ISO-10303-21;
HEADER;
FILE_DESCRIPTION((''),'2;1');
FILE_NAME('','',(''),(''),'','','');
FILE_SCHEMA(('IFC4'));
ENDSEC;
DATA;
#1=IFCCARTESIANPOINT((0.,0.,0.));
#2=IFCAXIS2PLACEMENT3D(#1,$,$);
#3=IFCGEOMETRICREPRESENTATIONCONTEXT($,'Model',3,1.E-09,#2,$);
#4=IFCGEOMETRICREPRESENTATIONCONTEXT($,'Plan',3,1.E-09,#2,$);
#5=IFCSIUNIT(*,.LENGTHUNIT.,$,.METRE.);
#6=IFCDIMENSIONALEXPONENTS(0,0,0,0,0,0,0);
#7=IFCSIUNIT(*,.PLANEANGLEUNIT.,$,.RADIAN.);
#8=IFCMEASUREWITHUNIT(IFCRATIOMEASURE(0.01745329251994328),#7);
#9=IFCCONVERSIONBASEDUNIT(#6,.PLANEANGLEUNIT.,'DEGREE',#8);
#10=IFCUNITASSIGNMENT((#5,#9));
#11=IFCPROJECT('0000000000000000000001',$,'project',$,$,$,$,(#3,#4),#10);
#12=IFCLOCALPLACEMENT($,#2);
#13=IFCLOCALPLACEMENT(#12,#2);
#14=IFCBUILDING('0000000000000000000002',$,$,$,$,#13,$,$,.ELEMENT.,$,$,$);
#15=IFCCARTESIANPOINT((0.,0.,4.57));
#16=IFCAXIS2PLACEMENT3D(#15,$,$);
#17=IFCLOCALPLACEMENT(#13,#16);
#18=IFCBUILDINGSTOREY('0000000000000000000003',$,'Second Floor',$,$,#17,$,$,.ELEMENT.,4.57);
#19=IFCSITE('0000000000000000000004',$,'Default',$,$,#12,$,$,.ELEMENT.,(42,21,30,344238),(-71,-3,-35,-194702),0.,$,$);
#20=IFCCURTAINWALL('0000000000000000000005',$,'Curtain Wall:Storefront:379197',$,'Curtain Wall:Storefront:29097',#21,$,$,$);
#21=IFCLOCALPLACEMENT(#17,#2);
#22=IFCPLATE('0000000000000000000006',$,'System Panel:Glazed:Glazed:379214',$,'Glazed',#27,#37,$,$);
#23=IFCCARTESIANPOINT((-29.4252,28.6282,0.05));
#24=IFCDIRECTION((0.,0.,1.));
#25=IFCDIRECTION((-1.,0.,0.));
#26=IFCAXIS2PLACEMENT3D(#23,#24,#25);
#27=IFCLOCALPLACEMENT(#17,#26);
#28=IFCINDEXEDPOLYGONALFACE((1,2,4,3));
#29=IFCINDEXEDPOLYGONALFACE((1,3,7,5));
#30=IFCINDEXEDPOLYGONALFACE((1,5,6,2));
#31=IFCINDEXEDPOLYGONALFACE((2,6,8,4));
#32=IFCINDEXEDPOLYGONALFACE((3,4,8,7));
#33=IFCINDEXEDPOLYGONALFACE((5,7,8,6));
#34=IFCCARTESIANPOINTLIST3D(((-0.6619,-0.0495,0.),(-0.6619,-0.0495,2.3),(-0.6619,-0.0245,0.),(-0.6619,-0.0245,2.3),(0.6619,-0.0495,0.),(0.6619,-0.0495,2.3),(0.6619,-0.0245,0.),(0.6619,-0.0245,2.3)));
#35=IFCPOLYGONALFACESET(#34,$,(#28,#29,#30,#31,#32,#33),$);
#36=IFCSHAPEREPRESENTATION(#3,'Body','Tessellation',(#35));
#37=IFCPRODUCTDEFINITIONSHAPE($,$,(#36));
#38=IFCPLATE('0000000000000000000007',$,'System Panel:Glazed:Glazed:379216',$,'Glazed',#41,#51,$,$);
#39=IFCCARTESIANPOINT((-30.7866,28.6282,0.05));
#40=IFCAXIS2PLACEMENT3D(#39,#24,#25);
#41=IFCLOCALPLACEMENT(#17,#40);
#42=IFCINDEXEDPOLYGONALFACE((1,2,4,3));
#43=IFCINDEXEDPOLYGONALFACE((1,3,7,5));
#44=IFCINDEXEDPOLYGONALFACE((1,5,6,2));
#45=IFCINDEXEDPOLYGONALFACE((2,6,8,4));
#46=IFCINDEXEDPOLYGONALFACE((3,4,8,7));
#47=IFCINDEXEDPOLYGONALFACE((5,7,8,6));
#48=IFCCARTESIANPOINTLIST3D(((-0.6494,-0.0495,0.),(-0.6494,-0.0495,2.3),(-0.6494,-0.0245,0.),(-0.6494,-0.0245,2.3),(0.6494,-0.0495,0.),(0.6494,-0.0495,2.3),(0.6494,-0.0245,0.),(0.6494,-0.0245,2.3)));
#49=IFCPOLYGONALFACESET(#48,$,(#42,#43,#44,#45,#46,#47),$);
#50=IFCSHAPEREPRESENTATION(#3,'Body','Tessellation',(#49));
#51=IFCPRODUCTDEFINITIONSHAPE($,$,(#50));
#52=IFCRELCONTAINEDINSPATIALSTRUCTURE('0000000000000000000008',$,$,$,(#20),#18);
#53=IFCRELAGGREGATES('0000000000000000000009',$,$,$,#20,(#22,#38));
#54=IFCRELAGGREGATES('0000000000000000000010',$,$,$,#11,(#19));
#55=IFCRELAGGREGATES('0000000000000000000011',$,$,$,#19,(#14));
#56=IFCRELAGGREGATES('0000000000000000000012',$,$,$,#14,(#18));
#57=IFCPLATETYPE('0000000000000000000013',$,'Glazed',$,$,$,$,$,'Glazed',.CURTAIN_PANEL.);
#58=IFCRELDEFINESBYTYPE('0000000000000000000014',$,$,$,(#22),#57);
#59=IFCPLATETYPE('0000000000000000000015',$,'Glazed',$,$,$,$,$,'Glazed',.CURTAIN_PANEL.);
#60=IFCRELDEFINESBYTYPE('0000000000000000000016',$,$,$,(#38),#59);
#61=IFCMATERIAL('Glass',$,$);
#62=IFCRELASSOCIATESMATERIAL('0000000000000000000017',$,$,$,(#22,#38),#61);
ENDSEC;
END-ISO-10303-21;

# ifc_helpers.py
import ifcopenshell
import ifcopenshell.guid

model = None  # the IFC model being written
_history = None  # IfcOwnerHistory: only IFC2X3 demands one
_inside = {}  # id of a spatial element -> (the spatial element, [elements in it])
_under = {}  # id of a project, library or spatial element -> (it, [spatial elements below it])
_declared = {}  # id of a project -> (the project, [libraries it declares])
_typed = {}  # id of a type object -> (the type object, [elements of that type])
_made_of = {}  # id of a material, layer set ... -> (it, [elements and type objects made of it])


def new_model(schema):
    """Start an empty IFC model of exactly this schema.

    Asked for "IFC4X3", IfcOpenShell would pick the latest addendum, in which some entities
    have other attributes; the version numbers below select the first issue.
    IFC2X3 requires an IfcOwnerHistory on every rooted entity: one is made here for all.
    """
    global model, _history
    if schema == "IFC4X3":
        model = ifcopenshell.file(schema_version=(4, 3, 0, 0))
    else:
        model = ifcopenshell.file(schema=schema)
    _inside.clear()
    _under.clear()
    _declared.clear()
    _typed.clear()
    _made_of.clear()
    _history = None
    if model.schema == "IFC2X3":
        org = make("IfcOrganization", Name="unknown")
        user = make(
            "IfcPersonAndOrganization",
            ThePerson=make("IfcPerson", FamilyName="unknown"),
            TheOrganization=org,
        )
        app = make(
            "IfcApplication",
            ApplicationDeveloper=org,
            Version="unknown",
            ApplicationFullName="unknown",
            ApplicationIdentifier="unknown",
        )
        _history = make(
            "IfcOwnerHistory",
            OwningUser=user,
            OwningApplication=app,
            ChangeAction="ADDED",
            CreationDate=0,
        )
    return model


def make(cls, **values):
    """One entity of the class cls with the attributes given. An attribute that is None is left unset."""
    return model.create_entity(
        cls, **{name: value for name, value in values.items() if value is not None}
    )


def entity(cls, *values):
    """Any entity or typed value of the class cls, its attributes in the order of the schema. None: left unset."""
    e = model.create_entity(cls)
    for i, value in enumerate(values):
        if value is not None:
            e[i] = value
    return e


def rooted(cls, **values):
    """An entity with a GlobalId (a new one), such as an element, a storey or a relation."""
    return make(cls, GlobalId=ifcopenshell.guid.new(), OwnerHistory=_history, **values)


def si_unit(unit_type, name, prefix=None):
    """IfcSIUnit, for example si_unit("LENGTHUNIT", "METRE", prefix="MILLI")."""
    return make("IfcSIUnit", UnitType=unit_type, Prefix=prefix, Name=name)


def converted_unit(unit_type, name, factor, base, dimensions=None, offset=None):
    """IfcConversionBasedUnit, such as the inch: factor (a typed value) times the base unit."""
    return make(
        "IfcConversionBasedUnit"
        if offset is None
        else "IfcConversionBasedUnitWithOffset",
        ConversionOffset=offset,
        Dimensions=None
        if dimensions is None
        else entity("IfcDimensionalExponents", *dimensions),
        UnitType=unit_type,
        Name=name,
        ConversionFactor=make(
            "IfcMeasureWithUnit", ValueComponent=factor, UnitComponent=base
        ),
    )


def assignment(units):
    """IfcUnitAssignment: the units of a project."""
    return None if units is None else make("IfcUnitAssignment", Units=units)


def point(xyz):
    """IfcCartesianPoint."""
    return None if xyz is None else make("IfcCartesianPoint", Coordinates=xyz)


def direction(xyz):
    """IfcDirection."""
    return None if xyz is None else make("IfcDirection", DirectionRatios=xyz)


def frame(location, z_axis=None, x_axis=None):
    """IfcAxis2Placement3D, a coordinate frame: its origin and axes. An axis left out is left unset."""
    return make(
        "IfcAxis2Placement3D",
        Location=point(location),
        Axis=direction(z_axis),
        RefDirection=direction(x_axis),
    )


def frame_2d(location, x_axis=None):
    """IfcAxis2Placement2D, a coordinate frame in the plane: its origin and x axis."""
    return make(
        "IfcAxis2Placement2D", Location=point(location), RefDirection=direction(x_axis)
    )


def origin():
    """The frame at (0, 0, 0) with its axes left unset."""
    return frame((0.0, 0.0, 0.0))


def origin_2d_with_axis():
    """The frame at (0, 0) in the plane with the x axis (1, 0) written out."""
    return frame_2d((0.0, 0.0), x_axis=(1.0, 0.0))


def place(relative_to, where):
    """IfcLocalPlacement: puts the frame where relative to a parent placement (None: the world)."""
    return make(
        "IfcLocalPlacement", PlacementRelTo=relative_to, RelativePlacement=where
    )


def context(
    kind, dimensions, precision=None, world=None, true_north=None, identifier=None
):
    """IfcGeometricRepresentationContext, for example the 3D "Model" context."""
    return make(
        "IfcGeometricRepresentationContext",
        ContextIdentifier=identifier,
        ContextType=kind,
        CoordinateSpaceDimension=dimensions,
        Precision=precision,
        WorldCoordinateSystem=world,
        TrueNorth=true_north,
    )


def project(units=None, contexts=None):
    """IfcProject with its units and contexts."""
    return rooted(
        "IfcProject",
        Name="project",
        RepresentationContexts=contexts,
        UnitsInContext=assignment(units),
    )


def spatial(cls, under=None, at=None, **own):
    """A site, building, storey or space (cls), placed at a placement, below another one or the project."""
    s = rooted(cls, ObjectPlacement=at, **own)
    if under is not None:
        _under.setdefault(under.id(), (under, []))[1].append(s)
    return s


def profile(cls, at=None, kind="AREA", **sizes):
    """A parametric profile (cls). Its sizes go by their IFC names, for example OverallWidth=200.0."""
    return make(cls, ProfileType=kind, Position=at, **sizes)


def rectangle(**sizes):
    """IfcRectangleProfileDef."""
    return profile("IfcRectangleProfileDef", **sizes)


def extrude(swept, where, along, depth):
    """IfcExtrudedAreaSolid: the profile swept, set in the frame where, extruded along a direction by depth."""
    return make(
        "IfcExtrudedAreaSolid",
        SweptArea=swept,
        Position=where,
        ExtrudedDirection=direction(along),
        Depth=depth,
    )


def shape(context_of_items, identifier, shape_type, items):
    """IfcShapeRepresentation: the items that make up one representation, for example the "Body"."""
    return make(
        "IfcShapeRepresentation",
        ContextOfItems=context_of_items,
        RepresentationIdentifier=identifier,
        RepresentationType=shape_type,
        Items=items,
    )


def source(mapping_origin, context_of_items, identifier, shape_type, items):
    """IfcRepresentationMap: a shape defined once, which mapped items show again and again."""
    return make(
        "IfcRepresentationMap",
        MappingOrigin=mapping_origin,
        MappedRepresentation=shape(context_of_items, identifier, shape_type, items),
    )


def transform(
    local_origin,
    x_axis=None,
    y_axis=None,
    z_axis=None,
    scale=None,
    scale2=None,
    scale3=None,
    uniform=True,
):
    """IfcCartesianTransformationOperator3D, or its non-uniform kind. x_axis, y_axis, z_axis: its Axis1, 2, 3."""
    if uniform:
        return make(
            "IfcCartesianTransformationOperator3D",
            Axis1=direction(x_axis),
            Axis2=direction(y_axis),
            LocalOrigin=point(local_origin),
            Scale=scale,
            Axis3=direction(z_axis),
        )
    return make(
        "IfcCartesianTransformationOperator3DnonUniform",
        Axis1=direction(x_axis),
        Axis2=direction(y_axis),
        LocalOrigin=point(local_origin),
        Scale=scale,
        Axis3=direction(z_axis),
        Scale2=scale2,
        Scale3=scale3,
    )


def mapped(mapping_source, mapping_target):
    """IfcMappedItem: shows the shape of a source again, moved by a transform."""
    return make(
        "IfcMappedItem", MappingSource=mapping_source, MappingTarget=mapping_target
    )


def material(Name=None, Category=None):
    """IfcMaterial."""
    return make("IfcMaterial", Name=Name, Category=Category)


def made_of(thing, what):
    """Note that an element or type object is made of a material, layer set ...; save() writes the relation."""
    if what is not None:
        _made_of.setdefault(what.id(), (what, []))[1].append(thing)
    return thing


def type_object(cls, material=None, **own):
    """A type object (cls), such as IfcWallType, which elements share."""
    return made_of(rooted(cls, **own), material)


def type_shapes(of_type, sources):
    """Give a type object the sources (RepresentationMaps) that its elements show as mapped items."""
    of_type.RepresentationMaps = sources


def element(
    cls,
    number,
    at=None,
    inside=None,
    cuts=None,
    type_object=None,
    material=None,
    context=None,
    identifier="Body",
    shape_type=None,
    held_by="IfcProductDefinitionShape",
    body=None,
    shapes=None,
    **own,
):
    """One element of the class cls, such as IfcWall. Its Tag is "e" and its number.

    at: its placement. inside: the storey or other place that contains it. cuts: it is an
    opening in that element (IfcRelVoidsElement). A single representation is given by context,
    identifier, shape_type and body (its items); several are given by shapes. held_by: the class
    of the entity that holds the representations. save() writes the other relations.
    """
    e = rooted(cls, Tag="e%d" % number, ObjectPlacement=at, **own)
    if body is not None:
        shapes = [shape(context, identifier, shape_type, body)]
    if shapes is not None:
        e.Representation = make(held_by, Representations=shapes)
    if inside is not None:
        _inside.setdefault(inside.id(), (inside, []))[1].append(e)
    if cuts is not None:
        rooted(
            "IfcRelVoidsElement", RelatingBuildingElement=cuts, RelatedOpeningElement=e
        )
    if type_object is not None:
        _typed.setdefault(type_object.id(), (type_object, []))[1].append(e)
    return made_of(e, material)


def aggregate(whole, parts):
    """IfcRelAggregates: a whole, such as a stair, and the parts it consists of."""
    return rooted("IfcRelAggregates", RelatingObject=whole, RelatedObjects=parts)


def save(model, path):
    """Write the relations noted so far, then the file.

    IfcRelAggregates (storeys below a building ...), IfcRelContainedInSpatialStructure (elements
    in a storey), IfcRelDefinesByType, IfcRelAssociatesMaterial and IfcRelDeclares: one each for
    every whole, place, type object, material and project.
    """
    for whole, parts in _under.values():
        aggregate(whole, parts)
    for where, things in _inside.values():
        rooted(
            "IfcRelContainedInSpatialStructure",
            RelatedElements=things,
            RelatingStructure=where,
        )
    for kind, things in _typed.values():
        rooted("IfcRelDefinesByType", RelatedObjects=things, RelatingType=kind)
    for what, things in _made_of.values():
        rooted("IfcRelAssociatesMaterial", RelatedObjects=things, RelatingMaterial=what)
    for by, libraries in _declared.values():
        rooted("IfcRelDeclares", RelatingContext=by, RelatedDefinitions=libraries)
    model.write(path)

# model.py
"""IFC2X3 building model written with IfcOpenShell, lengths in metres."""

from ifc_helpers import new_model, entity, si_unit, converted_unit, frame, origin, origin_2d_with_axis, place, context, project, spatial, rectangle, extrude, source, transform, mapped, material, type_object, type_shapes, element, aggregate, save


model = new_model("IFC2X3")

# Units and contexts
model_context = context("Model", 3, precision=1e-09, world=origin())
plan_context = context("Plan", 3, precision=1e-09, world=origin())
ifc_project = project(units=[si_unit("LENGTHUNIT", "METRE"), converted_unit("PLANEANGLEUNIT", "DEGREE", entity("IfcRatioMeasure", 0.01745329251994328), si_unit("PLANEANGLEUNIT", "RADIAN"), dimensions=[0, 0, 0, 0, 0, 0, 0])], contexts=[model_context, plan_context])

# Site, building, storey
site_placement = place(None, origin())
site = spatial("IfcSite", under=ifc_project, at=site_placement, Name="Default", CompositionType="ELEMENT", RefLatitude=(42, 21, 30, 344238), RefLongitude=(-71, -3, -35, -194702), RefElevation=0.0)
building_placement = place(site_placement, origin())
building = spatial("IfcBuilding", under=site, at=building_placement, CompositionType="ELEMENT")
storey_placement = place(building_placement, frame((0.0, 0.0, 4.57)))
storey = spatial("IfcBuildingStorey", under=building, at=storey_placement, Name="Second Floor", CompositionType="ELEMENT", Elevation=4.57)

# Curtain wall, plates
curtain_wall_placement = place(storey_placement, origin())
curtain_wall = element("IfcCurtainWall", 1, at=curtain_wall_placement, inside=storey, Name="Curtain Wall:Storefront:379197", ObjectType="Curtain Wall:Storefront:29097")
ifc_material_1 = material(Name="Glass")
plate_type_1 = type_object("IfcPlateType", Name="Glazed", ElementType="Glazed", PredefinedType="CURTAIN_PANEL")
shared_shape_1 = source(origin(), model_context, "Body", "SweptSolid", [
    extrude(rectangle(XDim=0.025, YDim=1.3239, at=origin_2d_with_axis()), frame((0.0, -0.037, 0.0), z_axis=(0.0, 0.0, 1.0), x_axis=(0.0, 1.0, 0.0)), (0.0, 0.0, 1.0), 2.3),
])
type_shapes(plate_type_1, [shared_shape_1])
plate_1_placement = place(storey_placement, frame((-29.4252, 28.6282, 0.05), z_axis=(0.0, 0.0, 1.0), x_axis=(-1.0, 0.0, 0.0)))
plate_1 = element("IfcPlate", 2, at=plate_1_placement, type_object=plate_type_1, material=ifc_material_1, Name="System Panel:Glazed:Glazed:379214", ObjectType="Glazed", context=model_context, shape_type="MappedRepresentation", body=[
    mapped(shared_shape_1, transform((0.0, 0.0, 0.0), scale=1.0)),
])
plate_type_2 = type_object("IfcPlateType", Name="Glazed", ElementType="Glazed", PredefinedType="CURTAIN_PANEL")
shared_shape_2 = source(origin(), model_context, "Body", "SweptSolid", [
    extrude(rectangle(XDim=0.025, YDim=1.2989, at=origin_2d_with_axis()), frame((0.0, -0.037, 0.0), z_axis=(0.0, 0.0, 1.0), x_axis=(0.0, 1.0, 0.0)), (0.0, 0.0, 1.0), 2.3),
])
type_shapes(plate_type_2, [shared_shape_2])
plate_2_placement = place(storey_placement, frame((-30.7866, 28.6282, 0.05), z_axis=(0.0, 0.0, 1.0), x_axis=(-1.0, 0.0, 0.0)))
plate_2 = element("IfcPlate", 3, at=plate_2_placement, type_object=plate_type_2, material=ifc_material_1, Name="System Panel:Glazed:Glazed:379216", ObjectType="Glazed", context=model_context, shape_type="MappedRepresentation", body=[
    mapped(shared_shape_2, transform((0.0, 0.0, 0.0), scale=1.0)),
])
aggregate(curtain_wall, [plate_1, plate_2])

save(model, "model.ifc")
